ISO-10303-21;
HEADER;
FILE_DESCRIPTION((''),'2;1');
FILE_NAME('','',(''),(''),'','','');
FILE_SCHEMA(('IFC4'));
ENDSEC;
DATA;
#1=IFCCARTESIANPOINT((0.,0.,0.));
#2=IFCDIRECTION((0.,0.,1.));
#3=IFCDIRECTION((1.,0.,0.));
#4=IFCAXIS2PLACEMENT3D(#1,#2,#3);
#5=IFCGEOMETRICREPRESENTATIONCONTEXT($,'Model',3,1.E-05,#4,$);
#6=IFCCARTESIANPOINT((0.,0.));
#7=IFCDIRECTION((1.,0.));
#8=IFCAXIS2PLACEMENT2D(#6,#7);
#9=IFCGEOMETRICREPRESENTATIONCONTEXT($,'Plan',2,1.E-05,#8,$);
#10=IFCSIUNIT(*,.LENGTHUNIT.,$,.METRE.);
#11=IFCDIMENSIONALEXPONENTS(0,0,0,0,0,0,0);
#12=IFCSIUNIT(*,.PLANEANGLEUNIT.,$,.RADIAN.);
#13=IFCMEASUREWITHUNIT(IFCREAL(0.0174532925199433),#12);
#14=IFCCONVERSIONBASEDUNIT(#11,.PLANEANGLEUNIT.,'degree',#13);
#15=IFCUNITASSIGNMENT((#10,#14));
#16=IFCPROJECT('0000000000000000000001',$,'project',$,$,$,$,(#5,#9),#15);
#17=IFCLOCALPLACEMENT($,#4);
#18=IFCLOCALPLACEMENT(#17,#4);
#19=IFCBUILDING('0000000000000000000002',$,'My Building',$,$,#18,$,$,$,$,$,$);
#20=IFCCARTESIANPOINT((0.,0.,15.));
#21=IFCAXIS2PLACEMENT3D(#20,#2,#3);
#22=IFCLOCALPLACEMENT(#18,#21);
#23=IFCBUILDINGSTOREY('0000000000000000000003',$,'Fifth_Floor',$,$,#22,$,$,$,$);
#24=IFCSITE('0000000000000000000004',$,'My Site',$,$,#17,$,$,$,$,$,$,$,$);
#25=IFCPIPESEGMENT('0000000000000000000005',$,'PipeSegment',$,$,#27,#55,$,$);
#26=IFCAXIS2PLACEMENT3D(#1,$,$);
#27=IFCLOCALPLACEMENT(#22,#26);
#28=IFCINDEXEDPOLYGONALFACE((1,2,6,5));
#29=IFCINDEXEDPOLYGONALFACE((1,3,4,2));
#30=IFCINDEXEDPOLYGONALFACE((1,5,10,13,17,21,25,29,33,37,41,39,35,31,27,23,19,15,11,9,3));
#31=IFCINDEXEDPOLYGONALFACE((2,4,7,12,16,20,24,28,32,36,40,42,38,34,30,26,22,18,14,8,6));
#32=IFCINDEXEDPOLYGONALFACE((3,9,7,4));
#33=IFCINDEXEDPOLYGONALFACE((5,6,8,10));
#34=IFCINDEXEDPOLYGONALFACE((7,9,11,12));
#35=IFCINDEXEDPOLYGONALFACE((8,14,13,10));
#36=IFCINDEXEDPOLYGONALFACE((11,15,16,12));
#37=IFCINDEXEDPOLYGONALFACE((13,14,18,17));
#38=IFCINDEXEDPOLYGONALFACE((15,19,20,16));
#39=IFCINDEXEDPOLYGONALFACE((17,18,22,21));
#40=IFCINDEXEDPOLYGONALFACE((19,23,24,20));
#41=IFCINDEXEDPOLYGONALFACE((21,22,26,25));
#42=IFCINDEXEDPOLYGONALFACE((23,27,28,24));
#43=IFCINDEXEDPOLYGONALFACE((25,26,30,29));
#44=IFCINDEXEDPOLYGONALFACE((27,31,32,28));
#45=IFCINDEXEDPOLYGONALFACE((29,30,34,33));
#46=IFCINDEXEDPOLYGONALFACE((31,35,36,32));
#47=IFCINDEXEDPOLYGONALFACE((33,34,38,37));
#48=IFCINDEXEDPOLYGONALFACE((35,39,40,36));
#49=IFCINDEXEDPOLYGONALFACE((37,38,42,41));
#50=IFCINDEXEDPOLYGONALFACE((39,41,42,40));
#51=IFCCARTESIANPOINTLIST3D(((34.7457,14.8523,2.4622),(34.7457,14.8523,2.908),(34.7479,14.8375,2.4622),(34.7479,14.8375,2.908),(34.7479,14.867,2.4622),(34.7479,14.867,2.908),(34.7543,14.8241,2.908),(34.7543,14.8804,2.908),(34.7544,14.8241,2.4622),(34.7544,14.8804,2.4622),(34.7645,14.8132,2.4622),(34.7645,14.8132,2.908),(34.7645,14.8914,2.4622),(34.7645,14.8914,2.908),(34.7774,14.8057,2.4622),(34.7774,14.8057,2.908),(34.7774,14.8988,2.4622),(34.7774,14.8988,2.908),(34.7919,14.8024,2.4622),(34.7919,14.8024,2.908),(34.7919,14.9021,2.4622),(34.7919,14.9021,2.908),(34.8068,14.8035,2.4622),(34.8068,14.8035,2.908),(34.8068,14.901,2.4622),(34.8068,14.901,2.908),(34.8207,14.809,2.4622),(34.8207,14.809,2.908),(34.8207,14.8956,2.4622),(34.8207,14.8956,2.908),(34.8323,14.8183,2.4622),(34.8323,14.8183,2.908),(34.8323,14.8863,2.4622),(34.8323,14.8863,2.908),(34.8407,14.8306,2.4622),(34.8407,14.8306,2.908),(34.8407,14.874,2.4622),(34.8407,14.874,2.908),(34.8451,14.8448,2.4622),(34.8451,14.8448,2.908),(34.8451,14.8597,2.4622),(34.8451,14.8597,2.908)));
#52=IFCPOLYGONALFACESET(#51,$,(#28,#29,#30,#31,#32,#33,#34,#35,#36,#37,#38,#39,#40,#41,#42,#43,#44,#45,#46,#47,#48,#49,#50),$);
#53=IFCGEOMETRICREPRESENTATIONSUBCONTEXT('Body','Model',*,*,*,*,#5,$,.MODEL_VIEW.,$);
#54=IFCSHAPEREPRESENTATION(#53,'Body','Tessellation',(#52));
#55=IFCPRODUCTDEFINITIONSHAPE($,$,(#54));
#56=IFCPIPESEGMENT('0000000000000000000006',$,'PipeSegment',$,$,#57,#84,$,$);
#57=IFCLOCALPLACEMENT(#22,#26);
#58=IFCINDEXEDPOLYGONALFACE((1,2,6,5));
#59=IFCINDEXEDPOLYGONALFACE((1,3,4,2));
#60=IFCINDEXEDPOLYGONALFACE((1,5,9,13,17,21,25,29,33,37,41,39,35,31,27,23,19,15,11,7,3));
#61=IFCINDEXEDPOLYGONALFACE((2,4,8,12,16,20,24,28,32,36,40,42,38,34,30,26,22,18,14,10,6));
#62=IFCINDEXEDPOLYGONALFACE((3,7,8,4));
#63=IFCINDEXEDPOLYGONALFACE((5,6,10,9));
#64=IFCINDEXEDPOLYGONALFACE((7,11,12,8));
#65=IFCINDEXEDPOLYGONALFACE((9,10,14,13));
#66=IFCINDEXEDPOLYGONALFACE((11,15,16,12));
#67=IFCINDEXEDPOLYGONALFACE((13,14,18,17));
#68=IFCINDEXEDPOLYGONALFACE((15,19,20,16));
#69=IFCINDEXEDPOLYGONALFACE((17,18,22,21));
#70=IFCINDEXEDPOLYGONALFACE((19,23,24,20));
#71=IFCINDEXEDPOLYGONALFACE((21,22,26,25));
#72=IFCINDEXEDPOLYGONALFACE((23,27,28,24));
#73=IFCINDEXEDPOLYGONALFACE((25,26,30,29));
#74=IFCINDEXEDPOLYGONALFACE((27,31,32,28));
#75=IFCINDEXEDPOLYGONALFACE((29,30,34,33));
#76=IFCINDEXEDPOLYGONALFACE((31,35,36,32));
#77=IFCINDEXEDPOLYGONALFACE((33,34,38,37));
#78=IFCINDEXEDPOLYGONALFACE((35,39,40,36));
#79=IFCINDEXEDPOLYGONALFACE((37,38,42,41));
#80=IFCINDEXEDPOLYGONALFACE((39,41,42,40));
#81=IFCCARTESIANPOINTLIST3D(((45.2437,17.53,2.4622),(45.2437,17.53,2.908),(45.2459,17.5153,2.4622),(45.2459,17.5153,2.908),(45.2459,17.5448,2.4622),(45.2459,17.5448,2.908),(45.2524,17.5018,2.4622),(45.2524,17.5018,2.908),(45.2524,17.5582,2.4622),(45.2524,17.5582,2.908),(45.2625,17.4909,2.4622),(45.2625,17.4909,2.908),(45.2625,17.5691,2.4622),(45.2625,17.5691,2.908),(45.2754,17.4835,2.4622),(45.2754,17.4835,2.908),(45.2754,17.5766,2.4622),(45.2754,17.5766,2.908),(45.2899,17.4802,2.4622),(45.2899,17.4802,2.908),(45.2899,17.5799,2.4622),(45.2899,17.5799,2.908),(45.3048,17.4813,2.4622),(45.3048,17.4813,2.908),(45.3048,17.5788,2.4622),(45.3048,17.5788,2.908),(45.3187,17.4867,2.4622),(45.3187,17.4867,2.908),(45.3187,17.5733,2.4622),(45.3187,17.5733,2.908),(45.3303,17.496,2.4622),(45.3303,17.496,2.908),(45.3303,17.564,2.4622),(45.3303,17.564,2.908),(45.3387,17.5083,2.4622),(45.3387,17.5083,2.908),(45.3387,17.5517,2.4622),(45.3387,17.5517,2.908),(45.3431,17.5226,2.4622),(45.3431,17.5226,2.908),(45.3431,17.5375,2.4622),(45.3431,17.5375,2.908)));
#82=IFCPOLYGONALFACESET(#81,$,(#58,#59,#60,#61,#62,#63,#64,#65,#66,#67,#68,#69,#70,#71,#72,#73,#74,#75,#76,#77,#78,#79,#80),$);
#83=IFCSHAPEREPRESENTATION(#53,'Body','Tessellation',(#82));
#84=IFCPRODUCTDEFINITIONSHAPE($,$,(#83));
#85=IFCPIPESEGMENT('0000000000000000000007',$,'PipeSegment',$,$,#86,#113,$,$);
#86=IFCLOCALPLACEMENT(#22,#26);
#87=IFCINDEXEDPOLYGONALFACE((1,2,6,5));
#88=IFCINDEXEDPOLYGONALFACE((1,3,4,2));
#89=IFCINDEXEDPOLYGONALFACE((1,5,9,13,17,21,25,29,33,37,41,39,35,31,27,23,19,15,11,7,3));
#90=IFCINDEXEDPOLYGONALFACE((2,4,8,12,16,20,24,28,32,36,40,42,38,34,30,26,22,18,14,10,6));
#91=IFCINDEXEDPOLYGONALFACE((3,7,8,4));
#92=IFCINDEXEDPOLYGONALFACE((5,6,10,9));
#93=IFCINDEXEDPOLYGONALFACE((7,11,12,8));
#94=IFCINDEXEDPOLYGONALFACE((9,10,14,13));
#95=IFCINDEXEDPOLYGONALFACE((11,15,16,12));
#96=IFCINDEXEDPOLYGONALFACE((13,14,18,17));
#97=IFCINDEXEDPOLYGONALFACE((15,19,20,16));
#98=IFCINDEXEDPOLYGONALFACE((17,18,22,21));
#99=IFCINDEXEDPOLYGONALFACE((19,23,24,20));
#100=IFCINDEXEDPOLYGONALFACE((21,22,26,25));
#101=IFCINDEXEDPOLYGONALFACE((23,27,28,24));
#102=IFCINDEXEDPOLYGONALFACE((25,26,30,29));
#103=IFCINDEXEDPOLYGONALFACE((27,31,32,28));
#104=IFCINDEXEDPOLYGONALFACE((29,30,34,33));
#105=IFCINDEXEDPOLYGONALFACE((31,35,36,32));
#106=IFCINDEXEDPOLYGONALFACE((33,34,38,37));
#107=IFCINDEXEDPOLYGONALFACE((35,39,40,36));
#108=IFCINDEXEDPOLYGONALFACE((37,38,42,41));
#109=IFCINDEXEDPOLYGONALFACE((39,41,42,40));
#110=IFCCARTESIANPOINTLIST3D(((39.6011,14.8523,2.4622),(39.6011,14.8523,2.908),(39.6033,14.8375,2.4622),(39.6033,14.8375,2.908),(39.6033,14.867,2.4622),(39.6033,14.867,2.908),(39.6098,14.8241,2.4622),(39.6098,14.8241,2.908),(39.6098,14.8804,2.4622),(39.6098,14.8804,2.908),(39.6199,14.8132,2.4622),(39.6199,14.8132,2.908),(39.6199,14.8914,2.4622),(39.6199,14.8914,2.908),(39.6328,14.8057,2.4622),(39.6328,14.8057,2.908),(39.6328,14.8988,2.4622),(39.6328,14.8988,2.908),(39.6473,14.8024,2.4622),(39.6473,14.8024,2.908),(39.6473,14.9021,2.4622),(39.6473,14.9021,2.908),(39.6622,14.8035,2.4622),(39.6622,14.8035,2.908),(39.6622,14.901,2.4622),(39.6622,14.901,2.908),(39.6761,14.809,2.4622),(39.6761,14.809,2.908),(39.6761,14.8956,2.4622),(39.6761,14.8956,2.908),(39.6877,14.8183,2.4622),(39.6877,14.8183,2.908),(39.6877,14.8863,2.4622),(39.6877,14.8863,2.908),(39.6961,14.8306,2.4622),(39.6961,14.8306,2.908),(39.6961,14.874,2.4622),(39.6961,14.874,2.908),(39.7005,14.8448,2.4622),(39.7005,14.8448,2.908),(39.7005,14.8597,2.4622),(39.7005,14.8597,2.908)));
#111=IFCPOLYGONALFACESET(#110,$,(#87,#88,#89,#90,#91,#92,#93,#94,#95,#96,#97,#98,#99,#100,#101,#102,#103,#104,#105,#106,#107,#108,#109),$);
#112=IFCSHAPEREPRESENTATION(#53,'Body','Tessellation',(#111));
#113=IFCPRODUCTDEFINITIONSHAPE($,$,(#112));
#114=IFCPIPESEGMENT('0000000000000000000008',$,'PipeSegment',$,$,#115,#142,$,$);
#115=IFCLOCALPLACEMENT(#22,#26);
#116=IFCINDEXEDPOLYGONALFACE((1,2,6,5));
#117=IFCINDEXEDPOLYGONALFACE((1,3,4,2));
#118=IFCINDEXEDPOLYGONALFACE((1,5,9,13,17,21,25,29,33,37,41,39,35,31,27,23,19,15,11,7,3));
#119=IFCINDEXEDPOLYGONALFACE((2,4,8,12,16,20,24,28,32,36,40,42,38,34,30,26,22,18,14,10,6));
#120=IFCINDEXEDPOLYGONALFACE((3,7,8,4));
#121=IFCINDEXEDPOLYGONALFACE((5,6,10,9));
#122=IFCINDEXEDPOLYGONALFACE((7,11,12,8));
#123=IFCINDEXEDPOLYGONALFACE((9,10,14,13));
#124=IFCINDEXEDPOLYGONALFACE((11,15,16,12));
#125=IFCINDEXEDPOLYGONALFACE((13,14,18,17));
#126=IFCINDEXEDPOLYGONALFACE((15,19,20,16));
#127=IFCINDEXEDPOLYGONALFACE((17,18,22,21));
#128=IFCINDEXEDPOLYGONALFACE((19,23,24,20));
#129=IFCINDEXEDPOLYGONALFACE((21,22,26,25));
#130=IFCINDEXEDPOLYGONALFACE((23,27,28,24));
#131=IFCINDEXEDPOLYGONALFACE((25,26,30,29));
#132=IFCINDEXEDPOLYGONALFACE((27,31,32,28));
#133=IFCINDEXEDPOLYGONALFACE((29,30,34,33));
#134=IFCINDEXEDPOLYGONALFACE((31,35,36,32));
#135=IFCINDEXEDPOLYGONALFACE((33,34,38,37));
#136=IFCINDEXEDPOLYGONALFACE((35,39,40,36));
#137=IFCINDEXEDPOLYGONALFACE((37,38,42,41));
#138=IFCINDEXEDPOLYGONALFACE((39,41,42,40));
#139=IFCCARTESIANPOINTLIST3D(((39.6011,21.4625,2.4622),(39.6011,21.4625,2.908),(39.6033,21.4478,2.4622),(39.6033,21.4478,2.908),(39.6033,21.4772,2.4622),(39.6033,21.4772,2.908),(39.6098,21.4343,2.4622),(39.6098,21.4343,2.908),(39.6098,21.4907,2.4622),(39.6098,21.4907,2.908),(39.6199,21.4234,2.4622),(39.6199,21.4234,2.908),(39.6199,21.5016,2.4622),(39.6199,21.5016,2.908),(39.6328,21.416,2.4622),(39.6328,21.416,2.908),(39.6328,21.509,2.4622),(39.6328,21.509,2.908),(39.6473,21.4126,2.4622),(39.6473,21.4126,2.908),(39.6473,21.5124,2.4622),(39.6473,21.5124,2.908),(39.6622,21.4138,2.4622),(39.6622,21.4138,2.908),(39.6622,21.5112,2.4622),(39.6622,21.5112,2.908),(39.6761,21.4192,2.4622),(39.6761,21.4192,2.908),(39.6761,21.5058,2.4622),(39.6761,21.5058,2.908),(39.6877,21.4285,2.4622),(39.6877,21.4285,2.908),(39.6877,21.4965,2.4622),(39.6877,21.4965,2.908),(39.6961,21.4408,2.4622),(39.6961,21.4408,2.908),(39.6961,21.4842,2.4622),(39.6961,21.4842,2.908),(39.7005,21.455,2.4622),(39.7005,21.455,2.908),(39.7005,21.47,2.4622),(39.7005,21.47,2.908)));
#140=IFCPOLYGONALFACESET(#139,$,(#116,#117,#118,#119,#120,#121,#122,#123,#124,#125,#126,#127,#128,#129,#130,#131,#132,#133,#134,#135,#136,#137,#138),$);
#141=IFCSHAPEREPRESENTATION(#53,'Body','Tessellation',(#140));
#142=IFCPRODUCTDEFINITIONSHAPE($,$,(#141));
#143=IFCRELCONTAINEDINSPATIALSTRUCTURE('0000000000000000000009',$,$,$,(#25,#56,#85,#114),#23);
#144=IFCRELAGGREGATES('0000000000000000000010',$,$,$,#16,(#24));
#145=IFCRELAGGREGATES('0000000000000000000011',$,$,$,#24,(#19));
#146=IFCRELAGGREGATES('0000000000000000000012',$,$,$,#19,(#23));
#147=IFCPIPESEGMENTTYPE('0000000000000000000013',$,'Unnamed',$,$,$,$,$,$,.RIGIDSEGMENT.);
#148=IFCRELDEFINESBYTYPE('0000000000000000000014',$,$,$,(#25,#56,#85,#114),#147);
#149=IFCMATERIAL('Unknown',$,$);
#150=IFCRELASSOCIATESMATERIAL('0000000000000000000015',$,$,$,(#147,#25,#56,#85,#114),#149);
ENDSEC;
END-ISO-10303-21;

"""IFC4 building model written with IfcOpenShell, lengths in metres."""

from ifc_helpers import new_model, entity, si_unit, converted_unit, frame, origin_with_axes, origin_2d_with_axis, place, context, subcontext, project, spatial, circle, extrude, material, material_profile, profile_set, profile_usage, type_object, element, save


model = new_model("IFC4")

# Units and contexts
model_context = context("Model", 3, precision=1e-05, world=origin_with_axes())
plan_context = context("Plan", 2, precision=1e-05, world=origin_2d_with_axis())
body_context_1 = subcontext(model_context, "Body", "Model", "MODEL_VIEW")
ifc_project = project(units=[si_unit("LENGTHUNIT", "METRE"), converted_unit("PLANEANGLEUNIT", "degree", entity("IfcReal", 0.0174532925199433), si_unit("PLANEANGLEUNIT", "RADIAN"), dimensions=[0, 0, 0, 0, 0, 0, 0])], contexts=[model_context, plan_context])

# Site, building, storey
site_placement = place(None, origin_with_axes())
site = spatial("IfcSite", under=ifc_project, at=site_placement, Name="My Site")
building_placement = place(site_placement, origin_with_axes())
building = spatial("IfcBuilding", under=site, at=building_placement, Name="My Building")
storey_placement = place(building_placement, frame((0.0, 0.0, 15.0), z_axis=(0.0, 0.0, 1.0), x_axis=(1.0, 0.0, 0.0)))
storey = spatial("IfcBuildingStorey", under=building, at=storey_placement, Name="Fifth_Floor")

# Shared definitions
ifc_material = material(Name="Unknown")

# Pipe segments
ifc_material_profile_1 = material_profile(ifc_material, circle(Radius=0.05))
ifc_profile_set_1 = profile_set([ifc_material_profile_1])
pipe_segment_type = type_object("IfcPipeSegmentType", Name="Unnamed", PredefinedType="RIGIDSEGMENT", material=ifc_profile_set_1)
ifc_profile_usage_1 = profile_usage(ifc_profile_set_1, cardinal=5)
pipe_segment_1_placement = place(storey_placement, frame((34.7957, 14.8523, 2.908), z_axis=(0.0, 0.0, -1.0), x_axis=(-1.0, 0.0, 0.0)))
element("IfcPipeSegment", 1, at=pipe_segment_1_placement, inside=storey, type_object=pipe_segment_type, material=ifc_profile_usage_1, Name="PipeSegment", context=body_context_1, shape_type="SweptSolid", body=[
    extrude(circle(Radius=0.05), origin_with_axes(), (0.0, 0.0, 1.0), 0.4458),
])
ifc_profile_usage_2 = profile_usage(ifc_profile_set_1, cardinal=5)
pipe_segment_2_placement = place(storey_placement, frame((45.2937, 17.53, 2.908), z_axis=(0.0, 0.0, -1.0), x_axis=(-1.0, 0.0, 0.0)))
element("IfcPipeSegment", 2, at=pipe_segment_2_placement, inside=storey, type_object=pipe_segment_type, material=ifc_profile_usage_2, Name="PipeSegment", context=body_context_1, shape_type="SweptSolid", body=[
    extrude(circle(Radius=0.05), origin_with_axes(), (0.0, 0.0, 1.0), 0.4458),
])
ifc_profile_usage_3 = profile_usage(ifc_profile_set_1, cardinal=5)
pipe_segment_3_placement = place(storey_placement, frame((39.6511, 14.8523, 2.908), z_axis=(0.0, 0.0, -1.0), x_axis=(-1.0, 0.0, 0.0)))
element("IfcPipeSegment", 3, at=pipe_segment_3_placement, inside=storey, type_object=pipe_segment_type, material=ifc_profile_usage_3, Name="PipeSegment", context=body_context_1, shape_type="SweptSolid", body=[
    extrude(circle(Radius=0.05), origin_with_axes(), (0.0, 0.0, 1.0), 0.4458),
])
ifc_profile_usage_4 = profile_usage(ifc_profile_set_1, cardinal=5)
pipe_segment_4_placement = place(storey_placement, frame((39.6511, 21.4625, 2.908), z_axis=(0.0, 0.0, -1.0), x_axis=(-1.0, 0.0, 0.0)))
element("IfcPipeSegment", 4, at=pipe_segment_4_placement, inside=storey, type_object=pipe_segment_type, material=ifc_profile_usage_4, Name="PipeSegment", context=body_context_1, shape_type="SweptSolid", body=[
    extrude(circle(Radius=0.05), origin_with_axes(), (0.0, 0.0, 1.0), 0.4458),
])

save(model, "model.ifc")
